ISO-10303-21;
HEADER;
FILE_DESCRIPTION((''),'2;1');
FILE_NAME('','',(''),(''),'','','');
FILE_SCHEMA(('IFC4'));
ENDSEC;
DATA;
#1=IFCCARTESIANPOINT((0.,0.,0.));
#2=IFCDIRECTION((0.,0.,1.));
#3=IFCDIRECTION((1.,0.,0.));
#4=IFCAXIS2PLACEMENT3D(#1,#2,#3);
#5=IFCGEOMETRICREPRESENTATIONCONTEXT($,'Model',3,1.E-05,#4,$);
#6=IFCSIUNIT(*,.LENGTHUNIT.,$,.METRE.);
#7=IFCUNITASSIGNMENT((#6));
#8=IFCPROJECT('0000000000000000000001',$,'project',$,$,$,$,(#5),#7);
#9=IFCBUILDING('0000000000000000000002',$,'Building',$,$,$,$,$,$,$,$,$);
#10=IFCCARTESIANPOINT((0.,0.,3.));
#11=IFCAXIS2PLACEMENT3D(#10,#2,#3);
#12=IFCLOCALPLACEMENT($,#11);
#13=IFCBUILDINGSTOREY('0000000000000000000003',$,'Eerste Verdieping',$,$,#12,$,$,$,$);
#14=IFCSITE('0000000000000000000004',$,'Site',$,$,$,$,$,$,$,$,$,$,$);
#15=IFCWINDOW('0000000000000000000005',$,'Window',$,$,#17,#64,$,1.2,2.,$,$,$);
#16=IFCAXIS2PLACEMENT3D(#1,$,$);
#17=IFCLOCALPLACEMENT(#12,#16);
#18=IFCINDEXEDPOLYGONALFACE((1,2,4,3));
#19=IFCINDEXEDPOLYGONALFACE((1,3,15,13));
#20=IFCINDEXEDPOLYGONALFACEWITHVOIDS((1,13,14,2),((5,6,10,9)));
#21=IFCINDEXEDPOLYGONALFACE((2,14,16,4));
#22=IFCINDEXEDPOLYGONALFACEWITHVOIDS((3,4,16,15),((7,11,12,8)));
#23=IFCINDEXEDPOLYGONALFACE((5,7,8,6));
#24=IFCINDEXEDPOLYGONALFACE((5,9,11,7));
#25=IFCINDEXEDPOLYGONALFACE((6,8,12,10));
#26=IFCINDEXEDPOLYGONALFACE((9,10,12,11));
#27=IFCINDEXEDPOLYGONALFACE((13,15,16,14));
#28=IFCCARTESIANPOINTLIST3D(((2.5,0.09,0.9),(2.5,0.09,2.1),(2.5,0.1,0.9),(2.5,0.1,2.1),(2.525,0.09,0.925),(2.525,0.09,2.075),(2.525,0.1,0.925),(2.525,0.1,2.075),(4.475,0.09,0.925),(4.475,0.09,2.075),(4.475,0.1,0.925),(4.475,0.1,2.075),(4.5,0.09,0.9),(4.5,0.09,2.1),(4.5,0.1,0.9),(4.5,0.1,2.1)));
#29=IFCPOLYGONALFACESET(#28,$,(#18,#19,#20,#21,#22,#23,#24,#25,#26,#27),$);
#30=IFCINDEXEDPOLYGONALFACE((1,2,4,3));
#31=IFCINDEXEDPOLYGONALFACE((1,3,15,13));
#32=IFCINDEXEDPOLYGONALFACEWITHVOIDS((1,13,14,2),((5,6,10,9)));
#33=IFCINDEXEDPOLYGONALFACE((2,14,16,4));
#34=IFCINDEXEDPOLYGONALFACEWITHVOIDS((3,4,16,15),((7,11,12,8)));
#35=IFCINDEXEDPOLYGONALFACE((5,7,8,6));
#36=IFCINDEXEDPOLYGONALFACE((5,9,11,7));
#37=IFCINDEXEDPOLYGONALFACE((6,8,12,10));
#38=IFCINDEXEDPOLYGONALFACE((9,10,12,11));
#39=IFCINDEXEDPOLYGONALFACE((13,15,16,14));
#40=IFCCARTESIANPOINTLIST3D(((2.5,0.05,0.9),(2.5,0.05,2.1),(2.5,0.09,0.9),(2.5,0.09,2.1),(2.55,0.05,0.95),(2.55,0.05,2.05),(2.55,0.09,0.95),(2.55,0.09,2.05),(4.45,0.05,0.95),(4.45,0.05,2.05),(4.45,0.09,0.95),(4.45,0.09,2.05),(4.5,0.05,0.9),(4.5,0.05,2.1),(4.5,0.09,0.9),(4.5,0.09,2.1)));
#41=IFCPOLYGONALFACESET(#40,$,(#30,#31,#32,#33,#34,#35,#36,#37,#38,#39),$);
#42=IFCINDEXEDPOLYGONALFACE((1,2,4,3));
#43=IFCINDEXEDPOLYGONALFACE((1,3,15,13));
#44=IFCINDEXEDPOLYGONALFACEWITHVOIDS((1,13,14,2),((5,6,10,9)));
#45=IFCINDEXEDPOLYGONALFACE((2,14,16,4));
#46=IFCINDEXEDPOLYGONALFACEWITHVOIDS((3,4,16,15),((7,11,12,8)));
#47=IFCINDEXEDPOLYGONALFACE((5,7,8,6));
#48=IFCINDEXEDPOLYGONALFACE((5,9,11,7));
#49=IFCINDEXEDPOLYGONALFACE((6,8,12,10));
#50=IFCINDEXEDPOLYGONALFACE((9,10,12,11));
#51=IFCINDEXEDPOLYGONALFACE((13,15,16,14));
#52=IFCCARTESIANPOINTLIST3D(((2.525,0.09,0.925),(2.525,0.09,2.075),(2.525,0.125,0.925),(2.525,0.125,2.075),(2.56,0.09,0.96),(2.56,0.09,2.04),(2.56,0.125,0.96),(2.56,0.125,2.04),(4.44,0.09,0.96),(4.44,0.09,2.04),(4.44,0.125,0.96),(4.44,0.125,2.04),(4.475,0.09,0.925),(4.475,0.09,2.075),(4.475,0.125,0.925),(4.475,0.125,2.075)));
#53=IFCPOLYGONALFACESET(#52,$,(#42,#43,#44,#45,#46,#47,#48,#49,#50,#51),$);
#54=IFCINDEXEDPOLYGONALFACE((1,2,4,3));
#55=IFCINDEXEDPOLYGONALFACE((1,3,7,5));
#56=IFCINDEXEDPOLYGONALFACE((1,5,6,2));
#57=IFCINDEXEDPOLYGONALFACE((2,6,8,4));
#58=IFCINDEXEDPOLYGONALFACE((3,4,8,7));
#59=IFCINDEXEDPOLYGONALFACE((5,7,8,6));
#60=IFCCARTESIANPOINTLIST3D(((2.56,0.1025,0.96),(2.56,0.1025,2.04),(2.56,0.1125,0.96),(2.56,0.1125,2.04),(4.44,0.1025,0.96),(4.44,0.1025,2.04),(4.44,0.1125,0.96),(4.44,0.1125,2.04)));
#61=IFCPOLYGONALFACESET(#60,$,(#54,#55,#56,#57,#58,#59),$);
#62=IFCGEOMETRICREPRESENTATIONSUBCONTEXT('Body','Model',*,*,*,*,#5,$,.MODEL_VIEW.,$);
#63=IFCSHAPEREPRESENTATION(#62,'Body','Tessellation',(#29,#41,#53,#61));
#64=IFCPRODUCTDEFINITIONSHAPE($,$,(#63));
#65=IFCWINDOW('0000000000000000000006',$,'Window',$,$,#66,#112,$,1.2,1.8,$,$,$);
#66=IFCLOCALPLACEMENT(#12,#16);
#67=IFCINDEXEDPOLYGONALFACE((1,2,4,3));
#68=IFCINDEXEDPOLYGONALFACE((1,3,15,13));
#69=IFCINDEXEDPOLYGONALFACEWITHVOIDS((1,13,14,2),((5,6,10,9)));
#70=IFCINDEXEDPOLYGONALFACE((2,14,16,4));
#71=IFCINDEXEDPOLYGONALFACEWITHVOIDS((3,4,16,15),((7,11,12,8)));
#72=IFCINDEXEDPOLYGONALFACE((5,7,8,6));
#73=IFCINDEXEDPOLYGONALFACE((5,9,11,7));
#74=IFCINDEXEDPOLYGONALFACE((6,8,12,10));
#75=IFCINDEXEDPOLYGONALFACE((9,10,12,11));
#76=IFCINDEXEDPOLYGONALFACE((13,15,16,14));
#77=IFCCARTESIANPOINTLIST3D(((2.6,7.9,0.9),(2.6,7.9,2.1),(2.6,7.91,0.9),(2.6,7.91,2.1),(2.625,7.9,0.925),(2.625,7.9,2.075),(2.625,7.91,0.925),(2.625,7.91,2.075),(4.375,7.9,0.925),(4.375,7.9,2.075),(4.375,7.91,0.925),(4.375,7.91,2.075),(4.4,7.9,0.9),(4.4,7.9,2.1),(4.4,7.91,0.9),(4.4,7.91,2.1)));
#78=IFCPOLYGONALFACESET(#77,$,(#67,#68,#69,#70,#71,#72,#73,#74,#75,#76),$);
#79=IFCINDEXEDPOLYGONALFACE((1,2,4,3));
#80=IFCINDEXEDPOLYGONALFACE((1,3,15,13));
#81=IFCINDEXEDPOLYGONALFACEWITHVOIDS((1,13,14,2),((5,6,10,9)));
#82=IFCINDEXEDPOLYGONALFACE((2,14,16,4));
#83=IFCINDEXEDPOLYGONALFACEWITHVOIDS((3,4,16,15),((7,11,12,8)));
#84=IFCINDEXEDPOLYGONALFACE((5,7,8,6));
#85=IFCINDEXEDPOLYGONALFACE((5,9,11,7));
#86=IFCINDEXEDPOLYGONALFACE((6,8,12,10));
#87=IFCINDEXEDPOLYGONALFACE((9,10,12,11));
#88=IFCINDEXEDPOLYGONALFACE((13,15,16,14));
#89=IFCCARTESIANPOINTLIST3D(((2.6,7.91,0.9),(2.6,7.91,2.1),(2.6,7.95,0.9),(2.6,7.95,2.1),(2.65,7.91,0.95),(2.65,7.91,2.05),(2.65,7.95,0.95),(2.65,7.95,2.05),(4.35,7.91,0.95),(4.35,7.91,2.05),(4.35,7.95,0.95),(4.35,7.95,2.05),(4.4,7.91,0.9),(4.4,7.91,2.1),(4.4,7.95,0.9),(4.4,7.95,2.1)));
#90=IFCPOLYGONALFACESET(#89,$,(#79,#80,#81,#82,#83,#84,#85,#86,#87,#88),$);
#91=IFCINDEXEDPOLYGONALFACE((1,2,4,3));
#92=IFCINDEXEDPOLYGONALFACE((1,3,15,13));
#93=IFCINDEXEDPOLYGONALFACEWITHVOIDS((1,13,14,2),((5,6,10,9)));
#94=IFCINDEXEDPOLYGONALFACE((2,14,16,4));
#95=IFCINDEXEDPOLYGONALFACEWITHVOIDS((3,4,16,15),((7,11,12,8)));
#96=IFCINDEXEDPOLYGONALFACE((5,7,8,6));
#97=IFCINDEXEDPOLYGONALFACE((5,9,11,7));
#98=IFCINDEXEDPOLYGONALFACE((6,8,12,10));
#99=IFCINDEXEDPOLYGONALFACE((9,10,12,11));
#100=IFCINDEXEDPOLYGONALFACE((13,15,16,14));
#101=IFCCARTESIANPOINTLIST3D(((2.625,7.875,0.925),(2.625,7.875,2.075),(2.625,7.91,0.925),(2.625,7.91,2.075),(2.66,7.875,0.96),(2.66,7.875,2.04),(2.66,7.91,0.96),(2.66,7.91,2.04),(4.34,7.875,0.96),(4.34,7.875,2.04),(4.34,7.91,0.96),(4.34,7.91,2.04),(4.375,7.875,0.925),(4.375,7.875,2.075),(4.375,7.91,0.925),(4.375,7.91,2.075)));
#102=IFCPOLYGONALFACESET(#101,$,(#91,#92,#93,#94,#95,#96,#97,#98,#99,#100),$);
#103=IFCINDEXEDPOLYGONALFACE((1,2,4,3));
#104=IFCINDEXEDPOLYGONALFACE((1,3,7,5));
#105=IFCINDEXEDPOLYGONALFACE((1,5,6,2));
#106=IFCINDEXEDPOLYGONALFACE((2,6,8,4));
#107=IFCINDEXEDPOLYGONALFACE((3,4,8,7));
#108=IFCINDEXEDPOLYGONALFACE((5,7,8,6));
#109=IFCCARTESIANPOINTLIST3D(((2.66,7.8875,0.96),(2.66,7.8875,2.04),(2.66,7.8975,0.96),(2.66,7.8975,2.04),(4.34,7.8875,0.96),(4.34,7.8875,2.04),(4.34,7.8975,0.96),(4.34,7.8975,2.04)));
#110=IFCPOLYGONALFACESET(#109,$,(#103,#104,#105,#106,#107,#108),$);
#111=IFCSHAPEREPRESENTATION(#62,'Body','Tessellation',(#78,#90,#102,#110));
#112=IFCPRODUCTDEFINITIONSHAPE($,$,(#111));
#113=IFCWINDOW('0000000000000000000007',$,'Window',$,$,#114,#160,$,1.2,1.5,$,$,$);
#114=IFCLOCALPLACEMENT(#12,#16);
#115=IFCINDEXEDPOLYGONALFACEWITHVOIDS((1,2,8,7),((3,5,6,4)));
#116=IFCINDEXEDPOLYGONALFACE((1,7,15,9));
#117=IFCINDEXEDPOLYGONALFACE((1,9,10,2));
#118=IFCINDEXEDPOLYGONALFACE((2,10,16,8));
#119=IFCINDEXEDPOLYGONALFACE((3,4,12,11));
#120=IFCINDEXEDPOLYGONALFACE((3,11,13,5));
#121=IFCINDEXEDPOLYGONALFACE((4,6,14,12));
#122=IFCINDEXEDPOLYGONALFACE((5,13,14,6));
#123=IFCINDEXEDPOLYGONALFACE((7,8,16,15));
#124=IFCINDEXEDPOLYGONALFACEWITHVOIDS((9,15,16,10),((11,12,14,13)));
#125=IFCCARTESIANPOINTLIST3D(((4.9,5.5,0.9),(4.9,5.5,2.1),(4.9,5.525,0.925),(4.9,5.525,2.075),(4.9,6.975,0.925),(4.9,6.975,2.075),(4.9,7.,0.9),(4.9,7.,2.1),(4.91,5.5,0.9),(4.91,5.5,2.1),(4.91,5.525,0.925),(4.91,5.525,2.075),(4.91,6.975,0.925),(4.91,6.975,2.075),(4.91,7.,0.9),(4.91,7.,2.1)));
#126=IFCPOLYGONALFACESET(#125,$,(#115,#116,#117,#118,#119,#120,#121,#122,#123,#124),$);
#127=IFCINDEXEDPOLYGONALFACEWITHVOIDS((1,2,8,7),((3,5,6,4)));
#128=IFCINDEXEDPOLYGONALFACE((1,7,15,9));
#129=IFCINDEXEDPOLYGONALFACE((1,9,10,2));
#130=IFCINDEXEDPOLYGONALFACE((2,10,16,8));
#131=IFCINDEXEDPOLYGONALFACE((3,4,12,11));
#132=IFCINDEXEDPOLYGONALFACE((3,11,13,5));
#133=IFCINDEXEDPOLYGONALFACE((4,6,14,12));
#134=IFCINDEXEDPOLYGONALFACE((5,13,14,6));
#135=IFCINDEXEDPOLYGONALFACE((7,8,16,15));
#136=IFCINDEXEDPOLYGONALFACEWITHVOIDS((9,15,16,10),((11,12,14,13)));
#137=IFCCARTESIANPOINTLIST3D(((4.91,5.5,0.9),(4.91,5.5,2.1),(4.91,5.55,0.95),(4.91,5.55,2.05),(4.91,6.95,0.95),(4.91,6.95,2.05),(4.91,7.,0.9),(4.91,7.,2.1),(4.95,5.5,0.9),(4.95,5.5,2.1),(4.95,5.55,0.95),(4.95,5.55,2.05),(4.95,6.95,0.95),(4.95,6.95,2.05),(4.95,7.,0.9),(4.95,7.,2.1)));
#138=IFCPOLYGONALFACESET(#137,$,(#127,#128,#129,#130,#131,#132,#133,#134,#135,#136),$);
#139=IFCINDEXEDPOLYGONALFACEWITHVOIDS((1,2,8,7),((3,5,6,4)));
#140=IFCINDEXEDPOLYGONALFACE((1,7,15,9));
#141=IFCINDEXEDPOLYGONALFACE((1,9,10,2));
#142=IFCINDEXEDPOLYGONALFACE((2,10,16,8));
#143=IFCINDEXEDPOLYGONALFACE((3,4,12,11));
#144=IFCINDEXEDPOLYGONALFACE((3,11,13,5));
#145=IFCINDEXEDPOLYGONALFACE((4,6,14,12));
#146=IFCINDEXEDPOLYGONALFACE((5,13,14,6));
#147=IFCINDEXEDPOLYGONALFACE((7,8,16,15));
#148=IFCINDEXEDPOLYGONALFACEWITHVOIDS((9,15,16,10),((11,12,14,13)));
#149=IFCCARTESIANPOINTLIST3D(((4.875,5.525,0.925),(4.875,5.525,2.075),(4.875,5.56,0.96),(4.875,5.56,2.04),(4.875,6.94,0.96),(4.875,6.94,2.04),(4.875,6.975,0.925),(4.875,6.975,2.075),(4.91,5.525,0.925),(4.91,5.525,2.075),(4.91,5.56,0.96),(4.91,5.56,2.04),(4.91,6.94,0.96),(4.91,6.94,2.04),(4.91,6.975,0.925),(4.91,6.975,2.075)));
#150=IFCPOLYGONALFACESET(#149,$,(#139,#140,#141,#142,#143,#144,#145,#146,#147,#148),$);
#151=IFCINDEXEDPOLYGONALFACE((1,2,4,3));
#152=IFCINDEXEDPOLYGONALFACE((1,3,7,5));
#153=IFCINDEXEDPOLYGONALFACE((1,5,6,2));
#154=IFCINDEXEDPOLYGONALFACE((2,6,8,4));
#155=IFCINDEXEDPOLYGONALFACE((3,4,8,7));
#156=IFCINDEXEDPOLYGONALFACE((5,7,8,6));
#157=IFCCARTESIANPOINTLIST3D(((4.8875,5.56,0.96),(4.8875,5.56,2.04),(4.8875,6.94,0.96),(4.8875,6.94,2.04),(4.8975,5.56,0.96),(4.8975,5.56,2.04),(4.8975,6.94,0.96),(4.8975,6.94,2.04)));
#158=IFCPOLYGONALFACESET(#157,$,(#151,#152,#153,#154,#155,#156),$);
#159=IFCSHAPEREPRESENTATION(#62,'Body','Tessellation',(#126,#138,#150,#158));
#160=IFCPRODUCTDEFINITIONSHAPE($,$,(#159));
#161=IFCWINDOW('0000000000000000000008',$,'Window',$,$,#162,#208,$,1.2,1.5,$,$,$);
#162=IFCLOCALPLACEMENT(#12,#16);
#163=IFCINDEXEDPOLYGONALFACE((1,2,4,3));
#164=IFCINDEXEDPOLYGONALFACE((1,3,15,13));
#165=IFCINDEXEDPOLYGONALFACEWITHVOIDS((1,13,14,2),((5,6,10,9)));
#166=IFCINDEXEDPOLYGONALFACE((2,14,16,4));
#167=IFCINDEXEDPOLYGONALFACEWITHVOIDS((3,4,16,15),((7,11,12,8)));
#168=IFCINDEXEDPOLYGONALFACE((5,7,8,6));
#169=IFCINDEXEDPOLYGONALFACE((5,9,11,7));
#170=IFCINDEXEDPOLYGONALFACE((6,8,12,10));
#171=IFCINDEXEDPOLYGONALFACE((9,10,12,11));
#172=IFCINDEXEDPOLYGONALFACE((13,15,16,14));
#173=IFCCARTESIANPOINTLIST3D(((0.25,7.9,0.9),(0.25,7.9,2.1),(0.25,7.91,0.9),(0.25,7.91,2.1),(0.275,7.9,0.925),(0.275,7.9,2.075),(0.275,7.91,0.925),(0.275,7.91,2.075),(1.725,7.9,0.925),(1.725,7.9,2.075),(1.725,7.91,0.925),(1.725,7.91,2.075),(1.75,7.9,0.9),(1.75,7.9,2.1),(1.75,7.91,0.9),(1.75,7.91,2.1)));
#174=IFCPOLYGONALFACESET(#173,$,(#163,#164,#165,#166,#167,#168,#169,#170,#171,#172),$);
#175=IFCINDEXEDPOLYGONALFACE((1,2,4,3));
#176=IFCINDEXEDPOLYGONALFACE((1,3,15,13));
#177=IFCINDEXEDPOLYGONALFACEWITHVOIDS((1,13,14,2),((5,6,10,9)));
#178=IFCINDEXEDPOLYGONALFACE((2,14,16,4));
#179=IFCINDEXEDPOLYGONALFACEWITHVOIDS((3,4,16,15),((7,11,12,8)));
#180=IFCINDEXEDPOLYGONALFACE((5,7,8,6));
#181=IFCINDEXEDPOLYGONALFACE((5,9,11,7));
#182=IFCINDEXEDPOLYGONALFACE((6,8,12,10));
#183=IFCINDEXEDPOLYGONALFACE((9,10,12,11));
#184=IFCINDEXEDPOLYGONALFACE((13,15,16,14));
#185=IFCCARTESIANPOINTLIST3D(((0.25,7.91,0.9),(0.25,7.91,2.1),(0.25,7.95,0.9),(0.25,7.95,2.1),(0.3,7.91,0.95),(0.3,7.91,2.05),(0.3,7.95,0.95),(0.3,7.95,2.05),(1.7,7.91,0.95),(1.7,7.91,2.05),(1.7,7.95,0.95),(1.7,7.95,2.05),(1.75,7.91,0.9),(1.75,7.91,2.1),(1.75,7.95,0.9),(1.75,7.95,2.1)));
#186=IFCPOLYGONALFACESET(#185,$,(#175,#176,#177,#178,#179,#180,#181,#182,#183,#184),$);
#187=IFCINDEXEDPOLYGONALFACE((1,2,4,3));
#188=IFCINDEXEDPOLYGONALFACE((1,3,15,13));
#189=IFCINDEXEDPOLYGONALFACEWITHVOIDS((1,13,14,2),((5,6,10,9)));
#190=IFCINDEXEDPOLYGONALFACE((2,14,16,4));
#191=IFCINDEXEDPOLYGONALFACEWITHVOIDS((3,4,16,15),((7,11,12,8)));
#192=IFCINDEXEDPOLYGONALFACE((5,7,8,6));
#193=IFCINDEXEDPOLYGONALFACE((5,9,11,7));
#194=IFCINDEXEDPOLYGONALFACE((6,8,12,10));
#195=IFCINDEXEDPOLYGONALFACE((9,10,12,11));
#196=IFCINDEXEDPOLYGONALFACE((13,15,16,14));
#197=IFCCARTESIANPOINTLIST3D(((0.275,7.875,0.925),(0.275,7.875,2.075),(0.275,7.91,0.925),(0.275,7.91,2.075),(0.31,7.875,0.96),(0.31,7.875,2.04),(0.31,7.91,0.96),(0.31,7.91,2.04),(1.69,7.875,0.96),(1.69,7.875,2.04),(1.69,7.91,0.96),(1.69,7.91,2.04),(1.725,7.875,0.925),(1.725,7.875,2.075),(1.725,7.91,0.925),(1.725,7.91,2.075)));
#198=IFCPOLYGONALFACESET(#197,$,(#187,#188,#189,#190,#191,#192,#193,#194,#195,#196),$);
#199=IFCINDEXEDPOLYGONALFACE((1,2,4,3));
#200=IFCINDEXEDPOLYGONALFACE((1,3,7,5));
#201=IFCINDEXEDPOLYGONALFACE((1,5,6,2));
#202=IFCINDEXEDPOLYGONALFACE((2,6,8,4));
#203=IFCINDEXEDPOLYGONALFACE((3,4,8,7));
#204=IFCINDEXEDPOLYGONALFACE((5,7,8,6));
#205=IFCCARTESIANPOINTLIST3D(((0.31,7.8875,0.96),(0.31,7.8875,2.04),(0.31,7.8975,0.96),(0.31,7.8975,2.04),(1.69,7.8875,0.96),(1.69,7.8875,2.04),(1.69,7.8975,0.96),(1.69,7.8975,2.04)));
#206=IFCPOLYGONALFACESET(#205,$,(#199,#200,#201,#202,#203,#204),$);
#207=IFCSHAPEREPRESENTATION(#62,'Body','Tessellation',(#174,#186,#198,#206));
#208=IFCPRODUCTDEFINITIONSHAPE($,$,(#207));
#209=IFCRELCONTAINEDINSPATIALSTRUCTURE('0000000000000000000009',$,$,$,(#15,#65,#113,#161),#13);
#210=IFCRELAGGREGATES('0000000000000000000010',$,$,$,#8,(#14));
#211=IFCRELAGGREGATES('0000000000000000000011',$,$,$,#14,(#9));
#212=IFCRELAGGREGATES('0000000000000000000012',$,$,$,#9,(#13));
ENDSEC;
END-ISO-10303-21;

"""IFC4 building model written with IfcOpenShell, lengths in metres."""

from ifc_helpers import new_model, si_unit, frame, origin_with_axes, place, context, subcontext, project, spatial, line, indexed_curve, outline, extrude, element, save


model = new_model("IFC4")

# Units and contexts
model_context = context("Model", 3, precision=1e-05, world=origin_with_axes())
body_context = subcontext(model_context, "Body", "Model", "MODEL_VIEW")
ifc_project = project(units=[si_unit("LENGTHUNIT", "METRE")], contexts=[model_context])

# Site, building, storey
site = spatial("IfcSite", under=ifc_project, Name="Site")
building = spatial("IfcBuilding", under=site, Name="Building")
storey_placement = place(None, frame((0.0, 0.0, 3.0), z_axis=(0.0, 0.0, 1.0), x_axis=(1.0, 0.0, 0.0)))
storey = spatial("IfcBuildingStorey", under=building, at=storey_placement, Name="Eerste Verdieping")

# Windows
window_1_placement = place(storey_placement, frame((2.5, 0.0, 0.9), z_axis=(0.0, 0.0, 1.0), x_axis=(1.0, 0.0, 0.0)))
element("IfcWindow", 1, at=window_1_placement, inside=storey, Name="Window", OverallHeight=1.2, OverallWidth=2.0, context=body_context, shape_type="SweptSolid", body=[
    extrude(outline(indexed_curve([(0.0, 0.0), (2.0, 0.0), (2.0, 1.2), (0.0, 1.2)], segments=[line(1, 2, 3, 4, 1)]), holes=[indexed_curve([(0.025, 0.025), (1.975, 0.025), (1.975, 1.175), (0.025, 1.175)], segments=[line(1, 2, 3, 4, 1)])]), frame((0.0, 0.09, 0.0), z_axis=(0.0, -1.0, 0.0), x_axis=(1.0, 0.0, 0.0)), (0.0, 0.0, -1.0), 0.01),
    extrude(outline(indexed_curve([(0.0, 0.0), (2.0, 0.0), (2.0, 1.2), (0.0, 1.2)], segments=[line(1, 2, 3, 4, 1)]), holes=[indexed_curve([(0.05, 0.05), (1.95, 0.05), (1.95, 1.15), (0.05, 1.15)], segments=[line(1, 2, 3, 4, 1)])]), frame((0.0, 0.05, 0.0), z_axis=(0.0, -1.0, 0.0), x_axis=(1.0, 0.0, 0.0)), (0.0, 0.0, -1.0), 0.04),
    extrude(outline(indexed_curve([(0.0, 0.0), (1.95, 0.0), (1.95, 1.15), (0.0, 1.15)], segments=[line(1, 2, 3, 4, 1)]), holes=[indexed_curve([(0.035, 0.035), (1.915, 0.035), (1.915, 1.115), (0.035, 1.115)], segments=[line(1, 2, 3, 4, 1)])]), frame((0.025, 0.09, 0.025), z_axis=(0.0, -1.0, 0.0), x_axis=(1.0, 0.0, 0.0)), (0.0, 0.0, -1.0), 0.035),
    extrude(outline(indexed_curve([(0.035, 0.035), (1.915, 0.035), (1.915, 1.115), (0.035, 1.115)], segments=[line(1, 2, 3, 4, 1)])), frame((0.025, 0.1025, 0.025), z_axis=(0.0, -1.0, 0.0), x_axis=(1.0, 0.0, 0.0)), (0.0, 0.0, -1.0), 0.01),
])
window_2_placement = place(storey_placement, frame((4.4, 8.0, 0.9), z_axis=(0.0, 0.0, 1.0), x_axis=(-1.0, 0.0, 0.0)))
element("IfcWindow", 2, at=window_2_placement, inside=storey, Name="Window", OverallHeight=1.2, OverallWidth=1.8, context=body_context, shape_type="SweptSolid", body=[
    extrude(outline(indexed_curve([(0.0, 0.0), (1.8, 0.0), (1.8, 1.2), (0.0, 1.2)], segments=[line(1, 2, 3, 4, 1)]), holes=[indexed_curve([(0.025, 0.025), (1.775, 0.025), (1.775, 1.175), (0.025, 1.175)], segments=[line(1, 2, 3, 4, 1)])]), frame((0.0, 0.09, 0.0), z_axis=(0.0, -1.0, 0.0), x_axis=(1.0, 0.0, 0.0)), (0.0, 0.0, -1.0), 0.01),
    extrude(outline(indexed_curve([(0.0, 0.0), (1.8, 0.0), (1.8, 1.2), (0.0, 1.2)], segments=[line(1, 2, 3, 4, 1)]), holes=[indexed_curve([(0.05, 0.05), (1.75, 0.05), (1.75, 1.15), (0.05, 1.15)], segments=[line(1, 2, 3, 4, 1)])]), frame((0.0, 0.05, 0.0), z_axis=(0.0, -1.0, 0.0), x_axis=(1.0, 0.0, 0.0)), (0.0, 0.0, -1.0), 0.04),
    extrude(outline(indexed_curve([(0.0, 0.0), (1.75, 0.0), (1.75, 1.15), (0.0, 1.15)], segments=[line(1, 2, 3, 4, 1)]), holes=[indexed_curve([(0.035, 0.035), (1.715, 0.035), (1.715, 1.115), (0.035, 1.115)], segments=[line(1, 2, 3, 4, 1)])]), frame((0.025, 0.09, 0.025), z_axis=(0.0, -1.0, 0.0), x_axis=(1.0, 0.0, 0.0)), (0.0, 0.0, -1.0), 0.035),
    extrude(outline(indexed_curve([(0.035, 0.035), (1.715, 0.035), (1.715, 1.115), (0.035, 1.115)], segments=[line(1, 2, 3, 4, 1)])), frame((0.025, 0.1025, 0.025), z_axis=(0.0, -1.0, 0.0), x_axis=(1.0, 0.0, 0.0)), (0.0, 0.0, -1.0), 0.01),
])
for number, where, z_axis, x_axis, name in (
    (3, (5.0, 5.5, 0.9), (0.0, 0.0, 1.0), (0.0, 1.0, 0.0), "Window"),
    (4, (1.75, 8.0, 0.9), (0.0, 0.0, 1.0), (-1.0, 0.0, 0.0), "Window"),
):
    element("IfcWindow", number, at=place(storey_placement, frame(where, z_axis=z_axis, x_axis=x_axis)), inside=storey, Name=name, OverallHeight=1.2, OverallWidth=1.5, context=body_context, shape_type="SweptSolid", body=[
        extrude(outline(indexed_curve([(0.0, 0.0), (1.5, 0.0), (1.5, 1.2), (0.0, 1.2)], segments=[line(1, 2, 3, 4, 1)]), holes=[indexed_curve([(0.025, 0.025), (1.475, 0.025), (1.475, 1.175), (0.025, 1.175)], segments=[line(1, 2, 3, 4, 1)])]), frame((0.0, 0.09, 0.0), z_axis=(0.0, -1.0, 0.0), x_axis=(1.0, 0.0, 0.0)), (0.0, 0.0, -1.0), 0.01),
        extrude(outline(indexed_curve([(0.0, 0.0), (1.5, 0.0), (1.5, 1.2), (0.0, 1.2)], segments=[line(1, 2, 3, 4, 1)]), holes=[indexed_curve([(0.05, 0.05), (1.45, 0.05), (1.45, 1.15), (0.05, 1.15)], segments=[line(1, 2, 3, 4, 1)])]), frame((0.0, 0.05, 0.0), z_axis=(0.0, -1.0, 0.0), x_axis=(1.0, 0.0, 0.0)), (0.0, 0.0, -1.0), 0.04),
        extrude(outline(indexed_curve([(0.0, 0.0), (1.45, 0.0), (1.45, 1.15), (0.0, 1.15)], segments=[line(1, 2, 3, 4, 1)]), holes=[indexed_curve([(0.035, 0.035), (1.415, 0.035), (1.415, 1.115), (0.035, 1.115)], segments=[line(1, 2, 3, 4, 1)])]), frame((0.025, 0.09, 0.025), z_axis=(0.0, -1.0, 0.0), x_axis=(1.0, 0.0, 0.0)), (0.0, 0.0, -1.0), 0.035),
        extrude(outline(indexed_curve([(0.035, 0.035), (1.415, 0.035), (1.415, 1.115), (0.035, 1.115)], segments=[line(1, 2, 3, 4, 1)])), frame((0.025, 0.1025, 0.025), z_axis=(0.0, -1.0, 0.0), x_axis=(1.0, 0.0, 0.0)), (0.0, 0.0, -1.0), 0.01),
    ])

save(model, "model.ifc")
